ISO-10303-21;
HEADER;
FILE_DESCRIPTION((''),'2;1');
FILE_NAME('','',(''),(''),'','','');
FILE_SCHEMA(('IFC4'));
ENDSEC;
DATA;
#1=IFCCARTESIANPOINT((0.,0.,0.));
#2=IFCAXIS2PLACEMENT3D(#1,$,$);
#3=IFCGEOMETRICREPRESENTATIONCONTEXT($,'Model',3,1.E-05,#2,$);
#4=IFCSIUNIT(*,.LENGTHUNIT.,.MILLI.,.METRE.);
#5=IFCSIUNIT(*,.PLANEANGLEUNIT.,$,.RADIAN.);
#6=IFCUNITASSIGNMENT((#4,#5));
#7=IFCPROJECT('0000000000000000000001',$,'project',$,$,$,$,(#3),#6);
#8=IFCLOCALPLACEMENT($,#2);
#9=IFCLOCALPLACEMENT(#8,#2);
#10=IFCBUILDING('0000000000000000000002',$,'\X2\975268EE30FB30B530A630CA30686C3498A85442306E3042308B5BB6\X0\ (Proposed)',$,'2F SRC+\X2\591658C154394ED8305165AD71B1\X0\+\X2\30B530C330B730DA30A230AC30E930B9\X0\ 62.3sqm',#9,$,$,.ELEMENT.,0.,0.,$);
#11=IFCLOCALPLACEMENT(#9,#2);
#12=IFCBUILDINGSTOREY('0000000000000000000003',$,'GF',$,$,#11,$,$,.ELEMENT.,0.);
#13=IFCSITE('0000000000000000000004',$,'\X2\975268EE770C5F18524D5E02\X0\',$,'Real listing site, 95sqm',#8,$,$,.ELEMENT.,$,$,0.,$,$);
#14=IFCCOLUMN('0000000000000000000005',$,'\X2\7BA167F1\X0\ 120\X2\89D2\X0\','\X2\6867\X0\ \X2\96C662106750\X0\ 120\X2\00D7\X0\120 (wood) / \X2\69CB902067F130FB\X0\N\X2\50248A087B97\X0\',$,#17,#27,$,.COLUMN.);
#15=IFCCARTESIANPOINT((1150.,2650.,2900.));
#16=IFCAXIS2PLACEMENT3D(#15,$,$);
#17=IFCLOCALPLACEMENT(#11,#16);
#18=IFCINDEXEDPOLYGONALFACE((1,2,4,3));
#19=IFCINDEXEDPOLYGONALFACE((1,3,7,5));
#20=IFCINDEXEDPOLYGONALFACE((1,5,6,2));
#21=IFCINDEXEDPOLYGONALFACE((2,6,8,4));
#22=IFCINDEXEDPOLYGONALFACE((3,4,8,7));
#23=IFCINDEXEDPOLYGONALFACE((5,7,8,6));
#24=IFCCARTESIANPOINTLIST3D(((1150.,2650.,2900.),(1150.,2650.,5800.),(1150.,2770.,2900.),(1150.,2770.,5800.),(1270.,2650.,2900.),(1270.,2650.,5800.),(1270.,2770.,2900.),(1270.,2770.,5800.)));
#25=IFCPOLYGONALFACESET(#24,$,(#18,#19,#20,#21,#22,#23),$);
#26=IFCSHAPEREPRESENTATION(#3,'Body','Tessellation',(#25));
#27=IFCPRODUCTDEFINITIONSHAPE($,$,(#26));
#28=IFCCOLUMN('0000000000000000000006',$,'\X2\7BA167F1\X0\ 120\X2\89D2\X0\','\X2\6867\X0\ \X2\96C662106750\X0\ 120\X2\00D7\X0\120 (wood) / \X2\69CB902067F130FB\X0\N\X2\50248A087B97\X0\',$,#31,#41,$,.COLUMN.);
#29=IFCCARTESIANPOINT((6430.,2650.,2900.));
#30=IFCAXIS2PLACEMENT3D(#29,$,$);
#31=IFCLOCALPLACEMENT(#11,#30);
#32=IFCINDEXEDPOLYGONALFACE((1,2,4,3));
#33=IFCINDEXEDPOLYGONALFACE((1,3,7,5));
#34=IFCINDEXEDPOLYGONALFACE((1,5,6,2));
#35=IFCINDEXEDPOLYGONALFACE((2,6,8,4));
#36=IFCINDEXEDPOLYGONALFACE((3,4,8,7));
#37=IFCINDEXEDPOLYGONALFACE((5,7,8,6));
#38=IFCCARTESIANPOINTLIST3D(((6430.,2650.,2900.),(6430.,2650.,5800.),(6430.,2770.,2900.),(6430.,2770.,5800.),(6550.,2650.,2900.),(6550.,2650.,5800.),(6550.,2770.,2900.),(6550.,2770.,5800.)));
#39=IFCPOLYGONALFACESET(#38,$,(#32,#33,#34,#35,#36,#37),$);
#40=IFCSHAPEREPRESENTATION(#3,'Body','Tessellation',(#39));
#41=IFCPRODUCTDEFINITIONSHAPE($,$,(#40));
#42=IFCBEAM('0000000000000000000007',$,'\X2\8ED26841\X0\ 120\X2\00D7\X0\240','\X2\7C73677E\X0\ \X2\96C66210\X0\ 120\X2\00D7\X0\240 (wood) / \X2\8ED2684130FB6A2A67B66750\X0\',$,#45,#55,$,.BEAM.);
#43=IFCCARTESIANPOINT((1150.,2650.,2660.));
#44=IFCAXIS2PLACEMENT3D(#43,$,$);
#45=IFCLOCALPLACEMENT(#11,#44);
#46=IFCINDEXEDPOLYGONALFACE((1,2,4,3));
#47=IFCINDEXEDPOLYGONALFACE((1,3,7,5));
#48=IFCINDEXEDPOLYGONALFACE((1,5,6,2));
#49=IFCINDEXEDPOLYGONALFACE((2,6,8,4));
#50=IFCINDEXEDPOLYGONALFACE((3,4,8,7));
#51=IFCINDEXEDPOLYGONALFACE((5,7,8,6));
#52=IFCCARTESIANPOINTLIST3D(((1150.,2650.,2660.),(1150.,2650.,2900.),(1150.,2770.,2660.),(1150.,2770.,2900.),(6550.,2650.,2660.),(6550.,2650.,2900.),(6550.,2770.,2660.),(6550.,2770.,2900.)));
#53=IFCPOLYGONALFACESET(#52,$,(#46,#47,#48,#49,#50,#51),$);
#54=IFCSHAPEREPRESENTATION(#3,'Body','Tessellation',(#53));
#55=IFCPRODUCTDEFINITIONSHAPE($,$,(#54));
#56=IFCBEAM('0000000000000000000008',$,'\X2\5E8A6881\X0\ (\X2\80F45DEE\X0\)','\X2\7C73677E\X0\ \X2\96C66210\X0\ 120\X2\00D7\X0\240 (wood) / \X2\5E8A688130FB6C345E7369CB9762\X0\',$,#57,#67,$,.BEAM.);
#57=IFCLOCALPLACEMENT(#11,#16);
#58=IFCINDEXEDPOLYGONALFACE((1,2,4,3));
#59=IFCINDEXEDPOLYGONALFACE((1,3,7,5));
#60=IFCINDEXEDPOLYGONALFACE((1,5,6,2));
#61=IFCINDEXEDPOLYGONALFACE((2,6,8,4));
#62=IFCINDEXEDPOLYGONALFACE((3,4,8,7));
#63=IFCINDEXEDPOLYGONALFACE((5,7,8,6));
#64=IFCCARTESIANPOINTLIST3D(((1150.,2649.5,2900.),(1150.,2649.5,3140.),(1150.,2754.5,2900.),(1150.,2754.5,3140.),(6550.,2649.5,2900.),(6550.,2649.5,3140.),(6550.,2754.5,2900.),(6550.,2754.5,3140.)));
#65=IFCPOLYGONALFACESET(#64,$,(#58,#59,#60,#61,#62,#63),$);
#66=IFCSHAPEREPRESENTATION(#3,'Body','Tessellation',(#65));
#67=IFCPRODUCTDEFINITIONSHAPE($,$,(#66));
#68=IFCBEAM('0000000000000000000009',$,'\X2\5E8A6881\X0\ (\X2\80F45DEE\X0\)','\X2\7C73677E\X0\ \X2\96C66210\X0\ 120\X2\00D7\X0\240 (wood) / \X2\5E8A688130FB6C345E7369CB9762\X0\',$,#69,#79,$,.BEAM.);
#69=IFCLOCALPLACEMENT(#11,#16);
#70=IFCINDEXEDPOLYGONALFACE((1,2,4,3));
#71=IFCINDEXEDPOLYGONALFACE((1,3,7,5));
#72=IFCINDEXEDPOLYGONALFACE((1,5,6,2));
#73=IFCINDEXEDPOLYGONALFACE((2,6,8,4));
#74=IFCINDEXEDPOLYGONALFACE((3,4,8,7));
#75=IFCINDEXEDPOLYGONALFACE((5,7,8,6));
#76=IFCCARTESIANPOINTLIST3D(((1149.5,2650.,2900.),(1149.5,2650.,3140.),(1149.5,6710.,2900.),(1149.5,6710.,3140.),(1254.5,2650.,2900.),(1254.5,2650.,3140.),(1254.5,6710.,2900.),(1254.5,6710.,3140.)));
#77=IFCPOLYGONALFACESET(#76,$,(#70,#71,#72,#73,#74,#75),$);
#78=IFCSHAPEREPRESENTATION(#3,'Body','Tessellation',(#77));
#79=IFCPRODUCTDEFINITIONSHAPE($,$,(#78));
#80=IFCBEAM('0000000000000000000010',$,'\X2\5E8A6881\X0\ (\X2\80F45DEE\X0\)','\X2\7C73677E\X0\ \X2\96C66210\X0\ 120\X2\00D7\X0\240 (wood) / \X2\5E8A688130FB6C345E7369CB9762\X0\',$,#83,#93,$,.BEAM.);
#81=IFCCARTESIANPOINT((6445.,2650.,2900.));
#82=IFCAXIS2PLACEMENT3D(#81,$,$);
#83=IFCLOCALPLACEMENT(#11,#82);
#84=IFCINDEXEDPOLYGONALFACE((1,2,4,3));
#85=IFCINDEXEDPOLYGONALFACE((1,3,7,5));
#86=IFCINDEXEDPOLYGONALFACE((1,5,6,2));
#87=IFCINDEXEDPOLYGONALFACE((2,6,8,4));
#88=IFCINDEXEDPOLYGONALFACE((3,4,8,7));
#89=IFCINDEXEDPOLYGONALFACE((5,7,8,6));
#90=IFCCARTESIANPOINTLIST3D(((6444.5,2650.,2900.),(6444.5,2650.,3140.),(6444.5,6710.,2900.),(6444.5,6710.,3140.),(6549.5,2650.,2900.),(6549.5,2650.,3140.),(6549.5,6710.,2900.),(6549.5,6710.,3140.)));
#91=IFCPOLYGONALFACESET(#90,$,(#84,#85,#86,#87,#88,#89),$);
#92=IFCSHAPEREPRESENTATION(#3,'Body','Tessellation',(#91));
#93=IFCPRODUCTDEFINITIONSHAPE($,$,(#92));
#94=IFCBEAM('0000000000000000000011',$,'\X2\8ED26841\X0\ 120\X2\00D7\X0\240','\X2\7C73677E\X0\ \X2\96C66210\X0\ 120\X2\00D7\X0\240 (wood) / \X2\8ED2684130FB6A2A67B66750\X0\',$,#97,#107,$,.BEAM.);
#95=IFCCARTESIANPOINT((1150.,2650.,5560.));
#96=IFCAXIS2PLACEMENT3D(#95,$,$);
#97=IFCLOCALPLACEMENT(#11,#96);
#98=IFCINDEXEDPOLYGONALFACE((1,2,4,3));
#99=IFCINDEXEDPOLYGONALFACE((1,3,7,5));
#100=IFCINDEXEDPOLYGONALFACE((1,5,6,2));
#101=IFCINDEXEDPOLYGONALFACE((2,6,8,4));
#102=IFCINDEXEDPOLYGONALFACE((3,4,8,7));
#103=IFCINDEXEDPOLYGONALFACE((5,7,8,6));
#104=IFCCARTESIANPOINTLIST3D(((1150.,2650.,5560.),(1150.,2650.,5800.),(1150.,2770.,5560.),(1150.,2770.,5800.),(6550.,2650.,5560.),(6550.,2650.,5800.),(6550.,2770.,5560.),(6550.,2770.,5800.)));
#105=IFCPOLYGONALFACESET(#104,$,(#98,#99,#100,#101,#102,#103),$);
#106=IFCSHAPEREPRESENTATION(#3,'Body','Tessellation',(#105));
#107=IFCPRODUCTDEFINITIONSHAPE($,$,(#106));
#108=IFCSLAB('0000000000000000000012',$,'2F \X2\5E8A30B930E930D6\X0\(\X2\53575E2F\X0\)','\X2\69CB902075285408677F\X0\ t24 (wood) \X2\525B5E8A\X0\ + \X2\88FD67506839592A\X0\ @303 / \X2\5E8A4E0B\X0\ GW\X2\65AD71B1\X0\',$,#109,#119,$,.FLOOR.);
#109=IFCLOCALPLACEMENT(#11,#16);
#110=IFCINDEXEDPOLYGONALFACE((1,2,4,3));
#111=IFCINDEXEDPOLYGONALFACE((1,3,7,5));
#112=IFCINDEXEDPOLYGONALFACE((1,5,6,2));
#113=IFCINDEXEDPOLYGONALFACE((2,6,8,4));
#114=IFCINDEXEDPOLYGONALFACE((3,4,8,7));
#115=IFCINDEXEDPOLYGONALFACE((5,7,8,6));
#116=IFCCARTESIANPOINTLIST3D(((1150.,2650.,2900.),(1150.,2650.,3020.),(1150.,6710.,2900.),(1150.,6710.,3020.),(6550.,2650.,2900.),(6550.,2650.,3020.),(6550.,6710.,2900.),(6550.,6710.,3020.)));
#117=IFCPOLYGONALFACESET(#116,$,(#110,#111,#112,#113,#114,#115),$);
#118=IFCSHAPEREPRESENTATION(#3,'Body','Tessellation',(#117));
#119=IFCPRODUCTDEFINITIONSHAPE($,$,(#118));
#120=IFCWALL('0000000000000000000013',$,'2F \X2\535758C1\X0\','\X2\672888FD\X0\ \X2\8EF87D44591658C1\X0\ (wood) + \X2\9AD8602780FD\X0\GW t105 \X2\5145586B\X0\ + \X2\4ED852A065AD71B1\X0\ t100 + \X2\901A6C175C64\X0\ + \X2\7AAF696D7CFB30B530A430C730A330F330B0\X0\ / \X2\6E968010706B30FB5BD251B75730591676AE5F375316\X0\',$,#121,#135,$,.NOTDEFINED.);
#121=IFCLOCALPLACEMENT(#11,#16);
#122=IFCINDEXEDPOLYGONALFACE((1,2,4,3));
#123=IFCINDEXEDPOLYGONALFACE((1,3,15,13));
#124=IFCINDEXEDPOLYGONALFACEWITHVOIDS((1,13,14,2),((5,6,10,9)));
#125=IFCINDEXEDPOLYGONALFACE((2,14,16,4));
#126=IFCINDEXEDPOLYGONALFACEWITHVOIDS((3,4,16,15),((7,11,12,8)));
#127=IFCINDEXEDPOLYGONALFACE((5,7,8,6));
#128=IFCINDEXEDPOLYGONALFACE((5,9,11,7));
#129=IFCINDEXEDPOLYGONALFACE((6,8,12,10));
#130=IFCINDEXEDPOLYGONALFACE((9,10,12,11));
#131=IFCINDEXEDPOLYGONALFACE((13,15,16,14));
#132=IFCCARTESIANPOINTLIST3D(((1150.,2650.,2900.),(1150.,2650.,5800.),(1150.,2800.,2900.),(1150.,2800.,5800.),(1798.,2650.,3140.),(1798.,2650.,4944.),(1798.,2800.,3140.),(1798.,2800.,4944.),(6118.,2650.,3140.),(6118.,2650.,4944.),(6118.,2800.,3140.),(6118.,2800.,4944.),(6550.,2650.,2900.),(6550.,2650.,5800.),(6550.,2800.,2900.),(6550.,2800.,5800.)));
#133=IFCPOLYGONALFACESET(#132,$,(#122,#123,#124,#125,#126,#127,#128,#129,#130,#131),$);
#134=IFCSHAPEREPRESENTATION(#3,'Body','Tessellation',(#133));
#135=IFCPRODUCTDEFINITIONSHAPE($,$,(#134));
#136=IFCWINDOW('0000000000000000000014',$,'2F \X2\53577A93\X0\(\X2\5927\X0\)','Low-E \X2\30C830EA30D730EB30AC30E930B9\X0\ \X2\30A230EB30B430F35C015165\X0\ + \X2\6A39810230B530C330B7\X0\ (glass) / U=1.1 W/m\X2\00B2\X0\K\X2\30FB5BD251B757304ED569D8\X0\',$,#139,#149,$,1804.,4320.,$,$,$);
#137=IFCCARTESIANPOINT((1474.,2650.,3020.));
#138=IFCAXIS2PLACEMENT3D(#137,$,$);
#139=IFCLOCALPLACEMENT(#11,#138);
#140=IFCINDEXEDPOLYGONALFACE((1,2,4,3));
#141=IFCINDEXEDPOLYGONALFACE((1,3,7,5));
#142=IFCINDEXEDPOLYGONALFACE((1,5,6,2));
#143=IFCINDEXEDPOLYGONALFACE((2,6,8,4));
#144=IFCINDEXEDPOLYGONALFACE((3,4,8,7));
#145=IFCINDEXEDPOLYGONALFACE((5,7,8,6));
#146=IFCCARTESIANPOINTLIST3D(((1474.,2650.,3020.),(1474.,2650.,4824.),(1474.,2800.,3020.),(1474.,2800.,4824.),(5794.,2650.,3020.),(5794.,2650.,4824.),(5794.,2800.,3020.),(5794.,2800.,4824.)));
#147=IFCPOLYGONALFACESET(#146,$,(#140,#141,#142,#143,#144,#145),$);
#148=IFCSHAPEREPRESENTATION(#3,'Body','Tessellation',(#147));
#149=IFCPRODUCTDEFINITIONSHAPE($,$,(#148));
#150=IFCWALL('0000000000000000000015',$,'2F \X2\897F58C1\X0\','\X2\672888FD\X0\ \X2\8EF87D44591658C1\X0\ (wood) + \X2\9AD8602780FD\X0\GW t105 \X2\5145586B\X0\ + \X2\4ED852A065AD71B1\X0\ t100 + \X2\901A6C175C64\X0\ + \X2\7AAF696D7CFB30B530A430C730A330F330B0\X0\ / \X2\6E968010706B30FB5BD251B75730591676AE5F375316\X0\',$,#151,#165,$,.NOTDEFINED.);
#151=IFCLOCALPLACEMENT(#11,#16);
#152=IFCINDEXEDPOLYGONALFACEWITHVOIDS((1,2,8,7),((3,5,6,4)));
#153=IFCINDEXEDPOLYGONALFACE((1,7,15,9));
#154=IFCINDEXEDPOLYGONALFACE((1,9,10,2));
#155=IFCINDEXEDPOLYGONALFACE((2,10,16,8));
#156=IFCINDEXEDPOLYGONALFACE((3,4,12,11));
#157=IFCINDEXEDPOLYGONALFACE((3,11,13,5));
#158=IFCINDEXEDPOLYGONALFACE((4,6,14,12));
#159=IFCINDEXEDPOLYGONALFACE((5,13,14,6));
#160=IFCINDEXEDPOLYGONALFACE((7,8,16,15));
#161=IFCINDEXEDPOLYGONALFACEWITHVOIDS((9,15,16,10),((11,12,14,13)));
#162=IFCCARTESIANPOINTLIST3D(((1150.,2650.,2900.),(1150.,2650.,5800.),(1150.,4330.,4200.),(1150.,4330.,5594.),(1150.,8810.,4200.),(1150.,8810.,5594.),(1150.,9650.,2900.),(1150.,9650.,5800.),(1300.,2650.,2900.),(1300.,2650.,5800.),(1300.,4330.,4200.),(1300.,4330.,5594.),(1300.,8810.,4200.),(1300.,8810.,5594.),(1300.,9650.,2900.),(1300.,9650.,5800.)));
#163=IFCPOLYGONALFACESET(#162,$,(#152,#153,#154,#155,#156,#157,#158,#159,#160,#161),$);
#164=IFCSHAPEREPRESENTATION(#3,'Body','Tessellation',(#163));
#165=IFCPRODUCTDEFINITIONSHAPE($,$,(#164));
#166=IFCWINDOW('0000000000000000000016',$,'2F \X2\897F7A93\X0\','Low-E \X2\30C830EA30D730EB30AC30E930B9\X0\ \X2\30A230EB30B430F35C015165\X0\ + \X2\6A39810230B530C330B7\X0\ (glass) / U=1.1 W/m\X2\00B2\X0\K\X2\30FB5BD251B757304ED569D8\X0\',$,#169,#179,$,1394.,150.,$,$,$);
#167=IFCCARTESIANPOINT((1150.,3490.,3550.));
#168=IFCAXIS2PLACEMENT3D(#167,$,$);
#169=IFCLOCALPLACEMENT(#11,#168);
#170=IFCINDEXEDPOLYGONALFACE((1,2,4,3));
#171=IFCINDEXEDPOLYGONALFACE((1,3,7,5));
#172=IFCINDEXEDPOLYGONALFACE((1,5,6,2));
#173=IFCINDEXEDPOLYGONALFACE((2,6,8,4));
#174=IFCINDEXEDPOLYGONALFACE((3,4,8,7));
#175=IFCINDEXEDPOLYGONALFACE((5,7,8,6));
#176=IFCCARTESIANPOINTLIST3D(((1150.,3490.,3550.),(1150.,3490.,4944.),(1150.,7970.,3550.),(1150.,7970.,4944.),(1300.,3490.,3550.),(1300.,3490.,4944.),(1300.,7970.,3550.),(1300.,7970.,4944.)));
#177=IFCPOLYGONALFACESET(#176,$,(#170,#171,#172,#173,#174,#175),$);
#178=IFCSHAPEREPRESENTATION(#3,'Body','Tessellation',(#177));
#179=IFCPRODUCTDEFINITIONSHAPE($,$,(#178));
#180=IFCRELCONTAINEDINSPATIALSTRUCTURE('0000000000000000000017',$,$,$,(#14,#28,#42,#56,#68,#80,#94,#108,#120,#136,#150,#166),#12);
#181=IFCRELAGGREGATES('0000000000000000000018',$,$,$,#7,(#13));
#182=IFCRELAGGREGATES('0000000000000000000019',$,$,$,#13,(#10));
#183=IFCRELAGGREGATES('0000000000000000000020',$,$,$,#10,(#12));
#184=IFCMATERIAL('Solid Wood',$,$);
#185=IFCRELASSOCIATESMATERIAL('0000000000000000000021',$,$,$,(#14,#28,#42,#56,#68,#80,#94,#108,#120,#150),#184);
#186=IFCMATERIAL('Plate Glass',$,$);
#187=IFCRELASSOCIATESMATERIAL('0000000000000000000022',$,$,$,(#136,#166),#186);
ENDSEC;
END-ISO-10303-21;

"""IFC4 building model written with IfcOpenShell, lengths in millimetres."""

from ifc_helpers import new_model, si_unit, frame, frame_2d, origin, place, context, project, spatial, rectangle, extrude, material, element, fill, save


model = new_model("IFC4")

# Units and contexts
model_context = context("Model", 3, precision=1e-05, world=origin())
ifc_project = project(units=[si_unit("LENGTHUNIT", "METRE", prefix="MILLI"), si_unit("PLANEANGLEUNIT", "RADIAN")], contexts=[model_context])

# Site, building, storey
site_placement = place(None, origin())
site = spatial("IfcSite", under=ifc_project, at=site_placement, Name="青森県弘前市", ObjectType="Real listing site, 95sqm", CompositionType="ELEMENT", RefElevation=0.0)
building_placement = place(site_placement, origin())
building = spatial("IfcBuilding", under=site, at=building_placement, Name="青森・サウナと水風呂のある家 (Proposed)", ObjectType="2F SRC+外壁吹付け断熱+サッシペアガラス 62.3sqm", CompositionType="ELEMENT", ElevationOfRefHeight=0.0, ElevationOfTerrain=0.0)
storey_placement = place(building_placement, origin())
storey = spatial("IfcBuildingStorey", under=building, at=storey_placement, Name="GF", CompositionType="ELEMENT", Elevation=0.0)

# Columns
ifc_material_1 = material(Name="Solid Wood")
column_1_placement = place(storey_placement, frame((1150.0, 2650.0, 2900.0)))
element("IfcColumn", 1, at=column_1_placement, inside=storey, material=ifc_material_1, Name="管柱 120角", Description="桧 集成材 120×120 (wood) / 構造柱・N値計算", PredefinedType="COLUMN", context=model_context, shape_type="SweptSolid", body=[
    extrude(rectangle(XDim=120.0, YDim=120.0, at=frame_2d((60.0, 60.0))), frame((1150.0, 2650.0, 2900.0)), (0.0, 0.0, 1.0), 2900.0),
])
column_2_placement = place(storey_placement, frame((6430.0, 2650.0, 2900.0)))
element("IfcColumn", 2, at=column_2_placement, inside=storey, material=ifc_material_1, Name="管柱 120角", Description="桧 集成材 120×120 (wood) / 構造柱・N値計算", PredefinedType="COLUMN", context=model_context, shape_type="SweptSolid", body=[
    extrude(rectangle(XDim=120.0, YDim=120.0, at=frame_2d((60.0, 60.0))), frame((6430.0, 2650.0, 2900.0)), (0.0, 0.0, 1.0), 2900.0),
])

# Beams
beam_1_placement = place(storey_placement, frame((1150.0, 2650.0, 2660.0)))
element("IfcBeam", 3, at=beam_1_placement, inside=storey, material=ifc_material_1, Name="軒桁 120×240", Description="米松 集成 120×240 (wood) / 軒桁・横架材", PredefinedType="BEAM", context=model_context, shape_type="SweptSolid", body=[
    extrude(rectangle(XDim=5400.0, YDim=120.0, at=frame_2d((2700.0, 60.0))), frame((1150.0, 2650.0, 2660.0)), (0.0, 0.0, 1.0), 240.0),
])
beam_2_placement = place(storey_placement, frame((1150.0, 2650.0, 2900.0)))
element("IfcBeam", 4, at=beam_2_placement, inside=storey, material=ifc_material_1, Name="床梁 (胴差)", Description="米松 集成 120×240 (wood) / 床梁・水平構面", PredefinedType="BEAM", context=model_context, shape_type="SweptSolid", body=[
    extrude(rectangle(XDim=5400.0, YDim=105.0, at=frame_2d((2700.0, 52.0))), frame((1150.0, 2650.0, 2900.0)), (0.0, 0.0, 1.0), 240.0),
])
beam_3_placement = place(storey_placement, frame((1150.0, 2650.0, 2900.0)))
element("IfcBeam", 5, at=beam_3_placement, inside=storey, material=ifc_material_1, Name="床梁 (胴差)", Description="米松 集成 120×240 (wood) / 床梁・水平構面", PredefinedType="BEAM", context=model_context, shape_type="SweptSolid", body=[
    extrude(rectangle(XDim=105.0, YDim=4060.0, at=frame_2d((52.0, 2030.0))), frame((1150.0, 2650.0, 2900.0)), (0.0, 0.0, 1.0), 240.0),
])
beam_4_placement = place(storey_placement, frame((6445.0, 2650.0, 2900.0)))
element("IfcBeam", 6, at=beam_4_placement, inside=storey, material=ifc_material_1, Name="床梁 (胴差)", Description="米松 集成 120×240 (wood) / 床梁・水平構面", PredefinedType="BEAM", context=model_context, shape_type="SweptSolid", body=[
    extrude(rectangle(XDim=105.0, YDim=4060.0, at=frame_2d((52.0, 2030.0))), frame((6445.0, 2650.0, 2900.0)), (0.0, 0.0, 1.0), 240.0),
])
beam_5_placement = place(storey_placement, frame((1150.0, 2650.0, 5560.0)))
element("IfcBeam", 7, at=beam_5_placement, inside=storey, material=ifc_material_1, Name="軒桁 120×240", Description="米松 集成 120×240 (wood) / 軒桁・横架材", PredefinedType="BEAM", context=model_context, shape_type="SweptSolid", body=[
    extrude(rectangle(XDim=5400.0, YDim=120.0, at=frame_2d((2700.0, 60.0))), frame((1150.0, 2650.0, 5560.0)), (0.0, 0.0, 1.0), 240.0),
])

# Slab
slab_placement = place(storey_placement, frame((1150.0, 2650.0, 2900.0)))
element("IfcSlab", 8, at=slab_placement, inside=storey, material=ifc_material_1, Name="2F 床スラブ(南帯)", Description="構造用合板 t24 (wood) 剛床 + 製材根太 @303 / 床下 GW断熱", PredefinedType="FLOOR", context=model_context, shape_type="SweptSolid", body=[
    extrude(rectangle(XDim=5400.0, YDim=4060.0, at=frame_2d((2700.0, 2030.0))), frame((1150.0, 2650.0, 2900.0)), (0.0, 0.0, 1.0), 120.0),
])

# Walls, openings, windows
wall_1_placement = place(storey_placement, frame((1150.0, 2650.0, 2900.0)))
wall_1 = element("IfcWall", 9, at=wall_1_placement, inside=storey, material=ifc_material_1, Name="2F 南壁", Description="木製 軸組外壁 (wood) + 高性能GW t105 充填 + 付加断熱 t100 + 通気層 + 窯業系サイディング / 準耐火・寒冷地外皮強化", PredefinedType="NOTDEFINED", context=model_context, shape_type="SweptSolid", body=[
    extrude(rectangle(XDim=5400.0, YDim=150.0, at=frame_2d((2700.0, 75.0))), frame((1150.0, 2650.0, 2900.0)), (0.0, 0.0, 1.0), 2900.0),
])
opening_1_placement = place(storey_placement, frame((1474.0, 2650.0, 3020.0)))
opening_1 = element("IfcOpeningElement", 10, at=opening_1_placement, cuts=wall_1, PredefinedType="NOTDEFINED", context=model_context, shape_type="SweptSolid", body=[
    extrude(rectangle(XDim=4320.0, YDim=150.0, at=frame_2d((2160.0, 75.0))), frame((1474.0, 2650.0, 3020.0)), (0.0, 0.0, 1.0), 1804.0),
])
ifc_material_2 = material(Name="Plate Glass")
window_1_placement = place(storey_placement, frame((1474.0, 2650.0, 3020.0)))
window_1 = element("IfcWindow", 11, at=window_1_placement, inside=storey, material=ifc_material_2, Name="2F 南窓(大)", Description="Low-E トリプルガラス アルゴン封入 + 樹脂サッシ (glass) / U=1.1 W/m²K・寒冷地仕様", OverallHeight=1804.0, OverallWidth=4320.0, context=model_context, shape_type="SweptSolid", body=[
    extrude(rectangle(XDim=4320.0, YDim=150.0, at=frame_2d((2160.0, 75.0))), frame((1474.0, 2650.0, 3020.0)), (0.0, 0.0, 1.0), 1804.0),
])
fill(opening_1, window_1)
wall_2_placement = place(storey_placement, frame((1150.0, 2650.0, 2900.0)))
wall_2 = element("IfcWall", 12, at=wall_2_placement, inside=storey, material=ifc_material_1, Name="2F 西壁", Description="木製 軸組外壁 (wood) + 高性能GW t105 充填 + 付加断熱 t100 + 通気層 + 窯業系サイディング / 準耐火・寒冷地外皮強化", PredefinedType="NOTDEFINED", context=model_context, shape_type="SweptSolid", body=[
    extrude(rectangle(XDim=150.0, YDim=7000.0, at=frame_2d((75.0, 3500.0))), frame((1150.0, 2650.0, 2900.0)), (0.0, 0.0, 1.0), 2900.0),
])
opening_2_placement = place(storey_placement, frame((1150.0, 3490.0, 3550.0)))
opening_2 = element("IfcOpeningElement", 13, at=opening_2_placement, cuts=wall_2, PredefinedType="NOTDEFINED", context=model_context, shape_type="SweptSolid", body=[
    extrude(rectangle(XDim=150.0, YDim=4480.0, at=frame_2d((75.0, 2240.0))), frame((1150.0, 3490.0, 3550.0)), (0.0, 0.0, 1.0), 1394.0),
])
window_2_placement = place(storey_placement, frame((1150.0, 3490.0, 3550.0)))
window_2 = element("IfcWindow", 14, at=window_2_placement, inside=storey, material=ifc_material_2, Name="2F 西窓", Description="Low-E トリプルガラス アルゴン封入 + 樹脂サッシ (glass) / U=1.1 W/m²K・寒冷地仕様", OverallHeight=1394.0, OverallWidth=150.0, context=model_context, shape_type="SweptSolid", body=[
    extrude(rectangle(XDim=150.0, YDim=4480.0, at=frame_2d((75.0, 2240.0))), frame((1150.0, 3490.0, 3550.0)), (0.0, 0.0, 1.0), 1394.0),
])
fill(opening_2, window_2)

save(model, "model.ifc")
